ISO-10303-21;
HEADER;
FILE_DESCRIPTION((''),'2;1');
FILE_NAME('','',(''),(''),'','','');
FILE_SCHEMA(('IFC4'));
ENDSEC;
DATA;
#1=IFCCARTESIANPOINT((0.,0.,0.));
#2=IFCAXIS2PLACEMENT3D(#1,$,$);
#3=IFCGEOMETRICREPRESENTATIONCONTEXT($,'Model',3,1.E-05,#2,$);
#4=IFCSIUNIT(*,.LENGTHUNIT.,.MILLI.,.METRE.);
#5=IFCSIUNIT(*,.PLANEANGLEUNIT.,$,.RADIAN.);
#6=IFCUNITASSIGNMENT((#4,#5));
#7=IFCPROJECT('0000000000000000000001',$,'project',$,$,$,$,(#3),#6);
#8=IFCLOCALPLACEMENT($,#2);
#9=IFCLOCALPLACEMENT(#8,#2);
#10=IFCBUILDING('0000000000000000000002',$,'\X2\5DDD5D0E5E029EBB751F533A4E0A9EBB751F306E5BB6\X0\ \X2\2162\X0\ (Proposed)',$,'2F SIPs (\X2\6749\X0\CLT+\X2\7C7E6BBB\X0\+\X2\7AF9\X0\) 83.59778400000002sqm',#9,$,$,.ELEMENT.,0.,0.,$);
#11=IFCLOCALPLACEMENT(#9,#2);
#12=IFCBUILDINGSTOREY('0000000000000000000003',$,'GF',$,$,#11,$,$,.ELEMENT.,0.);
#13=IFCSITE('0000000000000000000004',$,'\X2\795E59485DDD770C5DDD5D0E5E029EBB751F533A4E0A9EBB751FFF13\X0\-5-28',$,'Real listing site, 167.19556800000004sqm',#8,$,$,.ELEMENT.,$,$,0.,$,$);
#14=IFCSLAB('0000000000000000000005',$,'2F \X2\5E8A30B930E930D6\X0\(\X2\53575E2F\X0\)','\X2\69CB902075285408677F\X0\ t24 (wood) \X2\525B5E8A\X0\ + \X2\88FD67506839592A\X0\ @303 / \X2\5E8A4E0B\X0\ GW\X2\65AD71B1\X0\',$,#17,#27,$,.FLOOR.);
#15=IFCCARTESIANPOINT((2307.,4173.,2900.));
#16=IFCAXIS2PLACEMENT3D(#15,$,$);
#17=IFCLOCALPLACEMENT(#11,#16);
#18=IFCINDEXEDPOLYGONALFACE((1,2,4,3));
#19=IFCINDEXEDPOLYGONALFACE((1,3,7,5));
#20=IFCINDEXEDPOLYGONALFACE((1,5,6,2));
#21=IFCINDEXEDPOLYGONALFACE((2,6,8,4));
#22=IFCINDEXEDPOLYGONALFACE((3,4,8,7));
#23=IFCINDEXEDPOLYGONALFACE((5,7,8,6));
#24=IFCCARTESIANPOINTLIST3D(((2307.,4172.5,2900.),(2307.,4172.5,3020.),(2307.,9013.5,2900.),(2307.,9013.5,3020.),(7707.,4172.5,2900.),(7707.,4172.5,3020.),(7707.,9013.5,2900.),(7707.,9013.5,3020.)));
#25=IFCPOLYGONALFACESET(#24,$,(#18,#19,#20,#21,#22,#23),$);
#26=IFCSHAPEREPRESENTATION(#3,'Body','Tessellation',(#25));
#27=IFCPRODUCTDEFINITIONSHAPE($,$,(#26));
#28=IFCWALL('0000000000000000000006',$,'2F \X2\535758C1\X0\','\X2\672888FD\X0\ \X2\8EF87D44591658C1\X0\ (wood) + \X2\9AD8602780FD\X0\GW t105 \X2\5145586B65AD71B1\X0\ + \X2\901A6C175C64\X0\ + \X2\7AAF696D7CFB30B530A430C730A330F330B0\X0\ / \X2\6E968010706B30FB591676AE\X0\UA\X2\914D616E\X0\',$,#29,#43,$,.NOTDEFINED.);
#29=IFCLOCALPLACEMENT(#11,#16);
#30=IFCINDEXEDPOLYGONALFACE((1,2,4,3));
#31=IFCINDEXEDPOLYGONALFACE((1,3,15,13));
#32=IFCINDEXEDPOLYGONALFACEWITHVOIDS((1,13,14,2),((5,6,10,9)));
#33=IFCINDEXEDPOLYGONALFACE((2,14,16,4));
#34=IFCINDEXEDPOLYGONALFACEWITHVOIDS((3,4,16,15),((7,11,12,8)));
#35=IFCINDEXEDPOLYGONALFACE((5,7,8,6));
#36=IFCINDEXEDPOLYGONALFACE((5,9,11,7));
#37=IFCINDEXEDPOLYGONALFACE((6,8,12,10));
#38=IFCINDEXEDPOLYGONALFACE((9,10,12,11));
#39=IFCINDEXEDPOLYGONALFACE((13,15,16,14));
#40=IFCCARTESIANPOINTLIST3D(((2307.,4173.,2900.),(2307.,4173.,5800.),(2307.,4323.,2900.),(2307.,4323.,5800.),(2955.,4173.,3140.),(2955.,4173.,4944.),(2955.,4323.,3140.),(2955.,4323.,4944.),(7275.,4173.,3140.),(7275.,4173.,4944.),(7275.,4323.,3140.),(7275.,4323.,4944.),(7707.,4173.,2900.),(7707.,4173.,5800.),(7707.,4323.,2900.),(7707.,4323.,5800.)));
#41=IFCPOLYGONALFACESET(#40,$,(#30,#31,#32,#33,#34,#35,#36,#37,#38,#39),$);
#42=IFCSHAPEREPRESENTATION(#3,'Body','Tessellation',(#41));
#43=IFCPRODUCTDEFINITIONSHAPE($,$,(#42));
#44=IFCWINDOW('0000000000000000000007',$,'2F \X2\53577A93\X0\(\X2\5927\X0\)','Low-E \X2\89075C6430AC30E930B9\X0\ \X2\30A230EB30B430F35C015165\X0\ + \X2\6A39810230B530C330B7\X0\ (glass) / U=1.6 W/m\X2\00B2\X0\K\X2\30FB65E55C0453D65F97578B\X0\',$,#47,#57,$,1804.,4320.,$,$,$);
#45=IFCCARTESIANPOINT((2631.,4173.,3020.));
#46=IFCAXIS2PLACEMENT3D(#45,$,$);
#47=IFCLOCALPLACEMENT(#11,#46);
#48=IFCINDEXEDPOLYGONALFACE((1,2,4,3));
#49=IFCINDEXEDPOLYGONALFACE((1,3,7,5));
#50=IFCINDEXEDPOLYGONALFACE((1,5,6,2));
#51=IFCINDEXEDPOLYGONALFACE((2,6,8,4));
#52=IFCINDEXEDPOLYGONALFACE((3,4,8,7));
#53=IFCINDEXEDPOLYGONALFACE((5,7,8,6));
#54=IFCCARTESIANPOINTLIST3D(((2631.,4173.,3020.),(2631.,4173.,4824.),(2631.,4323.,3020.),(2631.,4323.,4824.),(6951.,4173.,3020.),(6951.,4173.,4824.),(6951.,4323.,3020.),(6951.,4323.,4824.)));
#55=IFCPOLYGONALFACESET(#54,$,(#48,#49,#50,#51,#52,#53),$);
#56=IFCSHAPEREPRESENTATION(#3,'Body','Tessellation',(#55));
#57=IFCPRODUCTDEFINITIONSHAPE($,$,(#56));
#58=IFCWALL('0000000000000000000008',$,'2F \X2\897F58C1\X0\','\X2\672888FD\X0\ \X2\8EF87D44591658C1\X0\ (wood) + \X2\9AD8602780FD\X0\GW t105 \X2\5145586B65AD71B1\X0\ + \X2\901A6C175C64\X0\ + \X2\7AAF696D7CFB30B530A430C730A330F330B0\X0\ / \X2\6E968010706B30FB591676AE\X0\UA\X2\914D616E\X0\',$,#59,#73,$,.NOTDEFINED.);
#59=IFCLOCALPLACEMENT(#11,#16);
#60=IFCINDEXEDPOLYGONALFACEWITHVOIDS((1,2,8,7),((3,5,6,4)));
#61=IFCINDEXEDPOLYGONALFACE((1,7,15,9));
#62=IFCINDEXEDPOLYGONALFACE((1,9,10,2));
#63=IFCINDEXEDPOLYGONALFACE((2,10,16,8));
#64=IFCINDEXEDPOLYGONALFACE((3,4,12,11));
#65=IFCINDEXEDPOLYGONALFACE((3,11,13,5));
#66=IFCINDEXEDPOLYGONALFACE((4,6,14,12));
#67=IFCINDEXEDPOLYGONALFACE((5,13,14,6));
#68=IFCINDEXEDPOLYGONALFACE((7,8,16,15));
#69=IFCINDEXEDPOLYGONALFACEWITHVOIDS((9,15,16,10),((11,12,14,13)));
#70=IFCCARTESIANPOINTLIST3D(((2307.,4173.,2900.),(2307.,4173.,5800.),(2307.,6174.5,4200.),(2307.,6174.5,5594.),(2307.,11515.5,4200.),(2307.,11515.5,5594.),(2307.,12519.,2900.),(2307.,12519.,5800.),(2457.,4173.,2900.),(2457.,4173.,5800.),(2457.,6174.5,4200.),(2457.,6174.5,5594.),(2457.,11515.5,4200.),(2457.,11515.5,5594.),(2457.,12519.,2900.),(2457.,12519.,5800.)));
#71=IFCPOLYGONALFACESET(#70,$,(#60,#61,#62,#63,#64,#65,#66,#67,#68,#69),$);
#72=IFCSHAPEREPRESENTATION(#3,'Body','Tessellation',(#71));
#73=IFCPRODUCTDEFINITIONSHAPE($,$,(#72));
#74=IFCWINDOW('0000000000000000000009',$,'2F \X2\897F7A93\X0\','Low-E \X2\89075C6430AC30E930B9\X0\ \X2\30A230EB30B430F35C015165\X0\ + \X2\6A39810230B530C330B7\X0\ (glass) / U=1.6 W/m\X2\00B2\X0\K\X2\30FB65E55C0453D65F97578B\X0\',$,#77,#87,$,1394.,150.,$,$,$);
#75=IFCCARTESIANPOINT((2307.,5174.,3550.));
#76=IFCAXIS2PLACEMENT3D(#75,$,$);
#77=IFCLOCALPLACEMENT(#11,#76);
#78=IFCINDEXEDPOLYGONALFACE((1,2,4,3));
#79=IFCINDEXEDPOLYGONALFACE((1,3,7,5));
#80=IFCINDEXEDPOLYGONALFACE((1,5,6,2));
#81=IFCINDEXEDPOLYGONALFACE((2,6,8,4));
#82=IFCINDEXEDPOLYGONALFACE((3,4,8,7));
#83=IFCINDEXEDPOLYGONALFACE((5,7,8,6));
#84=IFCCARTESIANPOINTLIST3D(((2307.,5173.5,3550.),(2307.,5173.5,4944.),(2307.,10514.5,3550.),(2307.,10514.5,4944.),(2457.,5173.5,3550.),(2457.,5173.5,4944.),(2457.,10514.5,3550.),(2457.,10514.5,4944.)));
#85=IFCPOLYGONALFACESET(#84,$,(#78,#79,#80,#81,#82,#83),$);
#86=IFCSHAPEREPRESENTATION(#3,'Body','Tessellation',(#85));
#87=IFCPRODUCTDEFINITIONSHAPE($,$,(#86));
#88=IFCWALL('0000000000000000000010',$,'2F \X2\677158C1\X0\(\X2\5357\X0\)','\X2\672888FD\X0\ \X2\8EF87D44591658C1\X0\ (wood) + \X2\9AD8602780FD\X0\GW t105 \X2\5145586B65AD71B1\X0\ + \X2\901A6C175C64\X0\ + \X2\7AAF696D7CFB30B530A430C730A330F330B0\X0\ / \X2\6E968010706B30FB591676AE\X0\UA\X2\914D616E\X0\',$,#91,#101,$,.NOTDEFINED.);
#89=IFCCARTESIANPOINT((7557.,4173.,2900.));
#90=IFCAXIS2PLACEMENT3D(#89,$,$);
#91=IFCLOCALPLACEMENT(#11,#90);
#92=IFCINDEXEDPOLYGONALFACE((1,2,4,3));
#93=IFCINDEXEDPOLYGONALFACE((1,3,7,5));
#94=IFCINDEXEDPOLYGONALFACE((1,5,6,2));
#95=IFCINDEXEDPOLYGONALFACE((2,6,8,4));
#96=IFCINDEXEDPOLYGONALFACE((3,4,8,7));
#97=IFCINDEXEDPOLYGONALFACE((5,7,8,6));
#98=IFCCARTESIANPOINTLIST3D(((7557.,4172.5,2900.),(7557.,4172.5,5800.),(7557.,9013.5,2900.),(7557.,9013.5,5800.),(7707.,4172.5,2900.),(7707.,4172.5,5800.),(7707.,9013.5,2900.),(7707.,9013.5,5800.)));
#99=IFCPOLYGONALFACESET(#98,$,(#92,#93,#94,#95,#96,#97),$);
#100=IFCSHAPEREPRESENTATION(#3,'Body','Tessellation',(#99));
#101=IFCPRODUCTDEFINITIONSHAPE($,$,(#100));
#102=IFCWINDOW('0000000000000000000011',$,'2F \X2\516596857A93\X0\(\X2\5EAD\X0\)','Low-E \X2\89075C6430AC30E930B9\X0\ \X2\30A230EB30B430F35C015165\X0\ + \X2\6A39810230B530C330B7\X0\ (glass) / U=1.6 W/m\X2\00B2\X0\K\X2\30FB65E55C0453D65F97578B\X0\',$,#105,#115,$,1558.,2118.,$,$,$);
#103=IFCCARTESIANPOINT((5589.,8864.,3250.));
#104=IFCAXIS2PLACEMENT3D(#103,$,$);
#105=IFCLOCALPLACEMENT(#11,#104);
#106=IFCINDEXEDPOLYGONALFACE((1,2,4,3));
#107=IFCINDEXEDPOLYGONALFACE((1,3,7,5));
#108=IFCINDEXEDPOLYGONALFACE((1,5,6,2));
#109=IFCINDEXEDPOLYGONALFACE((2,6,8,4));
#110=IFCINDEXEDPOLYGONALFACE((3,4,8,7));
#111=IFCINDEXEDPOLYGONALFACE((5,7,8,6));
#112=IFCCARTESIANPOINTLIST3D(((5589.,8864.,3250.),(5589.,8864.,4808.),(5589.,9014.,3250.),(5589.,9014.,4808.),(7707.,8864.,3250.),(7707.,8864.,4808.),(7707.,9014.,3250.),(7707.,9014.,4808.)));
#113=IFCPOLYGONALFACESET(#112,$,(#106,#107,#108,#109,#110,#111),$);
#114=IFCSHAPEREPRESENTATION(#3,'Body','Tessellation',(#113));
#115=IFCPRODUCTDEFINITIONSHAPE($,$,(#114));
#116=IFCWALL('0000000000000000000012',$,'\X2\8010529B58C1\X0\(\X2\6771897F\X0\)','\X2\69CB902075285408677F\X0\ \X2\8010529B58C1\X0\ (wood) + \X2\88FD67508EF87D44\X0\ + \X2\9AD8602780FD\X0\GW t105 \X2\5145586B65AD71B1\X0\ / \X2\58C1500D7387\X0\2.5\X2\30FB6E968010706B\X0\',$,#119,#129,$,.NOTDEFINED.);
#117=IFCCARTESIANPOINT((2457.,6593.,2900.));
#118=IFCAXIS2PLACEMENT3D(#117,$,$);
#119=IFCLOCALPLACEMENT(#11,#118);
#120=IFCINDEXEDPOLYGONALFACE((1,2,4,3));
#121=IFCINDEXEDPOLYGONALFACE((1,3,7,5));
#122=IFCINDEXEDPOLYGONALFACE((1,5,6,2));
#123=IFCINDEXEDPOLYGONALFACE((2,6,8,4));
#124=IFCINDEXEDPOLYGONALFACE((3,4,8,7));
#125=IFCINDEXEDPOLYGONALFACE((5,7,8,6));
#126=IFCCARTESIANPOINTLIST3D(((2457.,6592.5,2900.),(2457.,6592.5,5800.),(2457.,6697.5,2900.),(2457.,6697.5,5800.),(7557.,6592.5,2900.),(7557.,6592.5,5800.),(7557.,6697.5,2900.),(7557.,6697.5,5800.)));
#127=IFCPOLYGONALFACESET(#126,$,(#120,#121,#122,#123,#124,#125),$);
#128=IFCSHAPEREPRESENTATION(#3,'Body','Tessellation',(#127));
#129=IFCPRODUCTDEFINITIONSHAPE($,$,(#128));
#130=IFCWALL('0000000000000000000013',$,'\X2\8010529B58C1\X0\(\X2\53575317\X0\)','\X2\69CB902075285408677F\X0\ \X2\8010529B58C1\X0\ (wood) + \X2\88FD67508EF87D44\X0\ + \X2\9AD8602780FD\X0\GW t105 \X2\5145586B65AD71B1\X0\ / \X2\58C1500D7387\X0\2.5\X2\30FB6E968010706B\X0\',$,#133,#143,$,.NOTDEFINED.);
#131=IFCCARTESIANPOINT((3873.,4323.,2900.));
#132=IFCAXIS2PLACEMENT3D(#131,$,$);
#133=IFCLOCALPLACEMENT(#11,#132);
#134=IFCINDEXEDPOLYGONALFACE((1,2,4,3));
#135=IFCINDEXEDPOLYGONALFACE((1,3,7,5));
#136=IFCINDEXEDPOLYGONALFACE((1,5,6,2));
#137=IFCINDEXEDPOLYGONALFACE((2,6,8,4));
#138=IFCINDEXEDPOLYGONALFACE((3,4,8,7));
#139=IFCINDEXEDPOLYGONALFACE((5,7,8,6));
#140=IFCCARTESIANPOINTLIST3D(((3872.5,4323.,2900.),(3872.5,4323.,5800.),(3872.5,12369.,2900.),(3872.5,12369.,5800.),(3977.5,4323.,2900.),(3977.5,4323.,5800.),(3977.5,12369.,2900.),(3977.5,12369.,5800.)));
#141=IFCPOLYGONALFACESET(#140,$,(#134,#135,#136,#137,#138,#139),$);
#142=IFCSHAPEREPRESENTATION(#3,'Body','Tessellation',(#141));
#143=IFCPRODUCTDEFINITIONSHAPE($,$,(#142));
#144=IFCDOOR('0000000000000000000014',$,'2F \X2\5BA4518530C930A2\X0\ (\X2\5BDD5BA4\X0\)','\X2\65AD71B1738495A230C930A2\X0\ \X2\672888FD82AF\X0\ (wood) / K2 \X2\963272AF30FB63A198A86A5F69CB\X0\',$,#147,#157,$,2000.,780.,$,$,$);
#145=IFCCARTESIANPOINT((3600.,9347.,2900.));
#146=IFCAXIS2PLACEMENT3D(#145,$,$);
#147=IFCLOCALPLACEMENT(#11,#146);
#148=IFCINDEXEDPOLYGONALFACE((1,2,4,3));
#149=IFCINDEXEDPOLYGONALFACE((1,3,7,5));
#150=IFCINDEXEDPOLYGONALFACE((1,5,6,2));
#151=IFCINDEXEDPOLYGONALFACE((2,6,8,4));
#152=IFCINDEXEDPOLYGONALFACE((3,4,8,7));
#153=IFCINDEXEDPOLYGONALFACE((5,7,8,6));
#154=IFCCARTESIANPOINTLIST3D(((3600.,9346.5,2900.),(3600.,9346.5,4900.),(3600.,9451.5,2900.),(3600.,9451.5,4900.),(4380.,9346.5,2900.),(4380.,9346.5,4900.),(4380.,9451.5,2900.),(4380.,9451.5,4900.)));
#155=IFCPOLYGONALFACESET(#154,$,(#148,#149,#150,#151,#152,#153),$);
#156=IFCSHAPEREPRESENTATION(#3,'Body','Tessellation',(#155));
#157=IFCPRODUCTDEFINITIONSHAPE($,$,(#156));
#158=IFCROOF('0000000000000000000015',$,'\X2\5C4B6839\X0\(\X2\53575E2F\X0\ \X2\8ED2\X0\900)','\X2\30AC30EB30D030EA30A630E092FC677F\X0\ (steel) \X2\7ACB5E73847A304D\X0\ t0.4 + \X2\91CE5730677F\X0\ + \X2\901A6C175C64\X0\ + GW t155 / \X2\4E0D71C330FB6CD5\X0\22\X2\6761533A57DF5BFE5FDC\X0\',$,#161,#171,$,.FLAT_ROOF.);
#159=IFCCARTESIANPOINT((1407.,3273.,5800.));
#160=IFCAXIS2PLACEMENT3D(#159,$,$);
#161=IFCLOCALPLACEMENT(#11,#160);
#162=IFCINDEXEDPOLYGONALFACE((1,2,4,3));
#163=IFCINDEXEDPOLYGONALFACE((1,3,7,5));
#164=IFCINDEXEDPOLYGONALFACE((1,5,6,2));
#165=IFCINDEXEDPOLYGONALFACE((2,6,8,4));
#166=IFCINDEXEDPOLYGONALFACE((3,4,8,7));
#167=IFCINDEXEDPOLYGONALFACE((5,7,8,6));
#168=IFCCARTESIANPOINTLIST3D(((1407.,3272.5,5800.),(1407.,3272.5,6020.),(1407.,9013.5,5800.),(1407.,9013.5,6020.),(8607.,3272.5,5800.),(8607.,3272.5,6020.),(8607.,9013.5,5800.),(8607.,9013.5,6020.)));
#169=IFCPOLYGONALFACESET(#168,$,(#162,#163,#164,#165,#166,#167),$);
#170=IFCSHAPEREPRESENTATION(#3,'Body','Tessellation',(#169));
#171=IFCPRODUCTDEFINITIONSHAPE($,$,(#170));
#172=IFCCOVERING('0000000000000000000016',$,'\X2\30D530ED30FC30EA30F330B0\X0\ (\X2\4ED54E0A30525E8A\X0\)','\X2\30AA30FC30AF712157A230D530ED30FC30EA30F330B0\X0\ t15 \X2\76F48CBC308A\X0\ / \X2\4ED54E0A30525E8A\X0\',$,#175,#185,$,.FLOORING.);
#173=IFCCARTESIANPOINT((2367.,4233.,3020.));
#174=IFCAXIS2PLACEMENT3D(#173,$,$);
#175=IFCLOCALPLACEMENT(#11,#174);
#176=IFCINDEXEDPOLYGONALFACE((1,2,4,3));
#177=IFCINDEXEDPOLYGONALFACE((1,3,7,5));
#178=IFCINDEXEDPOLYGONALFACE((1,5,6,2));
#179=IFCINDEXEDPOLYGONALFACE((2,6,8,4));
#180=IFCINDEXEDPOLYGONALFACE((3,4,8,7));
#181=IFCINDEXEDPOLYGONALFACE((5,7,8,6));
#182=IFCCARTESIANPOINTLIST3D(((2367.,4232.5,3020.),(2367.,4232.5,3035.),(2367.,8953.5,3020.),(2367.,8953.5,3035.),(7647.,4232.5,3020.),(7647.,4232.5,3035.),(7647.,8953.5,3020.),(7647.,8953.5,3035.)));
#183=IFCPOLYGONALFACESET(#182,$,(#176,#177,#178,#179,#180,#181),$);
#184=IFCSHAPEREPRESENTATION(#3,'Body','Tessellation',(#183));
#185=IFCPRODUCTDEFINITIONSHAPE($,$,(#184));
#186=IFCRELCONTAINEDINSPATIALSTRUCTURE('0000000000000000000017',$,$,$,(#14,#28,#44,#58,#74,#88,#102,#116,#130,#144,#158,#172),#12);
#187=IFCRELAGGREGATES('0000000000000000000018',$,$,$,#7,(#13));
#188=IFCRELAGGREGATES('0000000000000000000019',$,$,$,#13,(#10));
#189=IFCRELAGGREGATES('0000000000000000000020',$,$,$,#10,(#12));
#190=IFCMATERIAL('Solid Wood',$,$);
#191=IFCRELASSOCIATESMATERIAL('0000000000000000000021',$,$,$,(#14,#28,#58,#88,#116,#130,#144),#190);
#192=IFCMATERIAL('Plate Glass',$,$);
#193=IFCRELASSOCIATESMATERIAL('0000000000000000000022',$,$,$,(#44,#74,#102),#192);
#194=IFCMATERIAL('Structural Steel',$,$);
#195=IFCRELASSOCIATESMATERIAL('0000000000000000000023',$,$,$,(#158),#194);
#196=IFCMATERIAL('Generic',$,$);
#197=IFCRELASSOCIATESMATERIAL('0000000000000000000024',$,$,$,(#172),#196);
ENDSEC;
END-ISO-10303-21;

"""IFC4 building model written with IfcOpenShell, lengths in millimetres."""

from ifc_helpers import new_model, si_unit, frame, frame_2d, origin, place, context, project, spatial, rectangle, extrude, material, element, fill, save


model = new_model("IFC4")

# Units and contexts
model_context = context("Model", 3, precision=1e-05, world=origin())
ifc_project = project(units=[si_unit("LENGTHUNIT", "METRE", prefix="MILLI"), si_unit("PLANEANGLEUNIT", "RADIAN")], contexts=[model_context])

# Site, building, storey
site_placement = place(None, origin())
site = spatial("IfcSite", under=ifc_project, at=site_placement, Name="神奈川県川崎市麻生区上麻生３-5-28", ObjectType="Real listing site, 167.19556800000004sqm", CompositionType="ELEMENT", RefElevation=0.0)
building_placement = place(site_placement, origin())
building = spatial("IfcBuilding", under=site, at=building_placement, Name="川崎市麻生区上麻生の家 Ⅲ (Proposed)", ObjectType="2F SIPs (杉CLT+籾殻+竹) 83.59778400000002sqm", CompositionType="ELEMENT", ElevationOfRefHeight=0.0, ElevationOfTerrain=0.0)
storey_placement = place(building_placement, origin())
storey = spatial("IfcBuildingStorey", under=building, at=storey_placement, Name="GF", CompositionType="ELEMENT", Elevation=0.0)

# Slab
ifc_material_1 = material(Name="Solid Wood")
slab_placement = place(storey_placement, frame((2307.0, 4173.0, 2900.0)))
element("IfcSlab", 1, at=slab_placement, inside=storey, material=ifc_material_1, Name="2F 床スラブ(南帯)", Description="構造用合板 t24 (wood) 剛床 + 製材根太 @303 / 床下 GW断熱", PredefinedType="FLOOR", context=model_context, shape_type="SweptSolid", body=[
    extrude(rectangle(XDim=5400.0, YDim=4841.0, at=frame_2d((2700.0, 2420.0))), frame((2307.0, 4173.0, 2900.0)), (0.0, 0.0, 1.0), 120.0),
])

# Walls, openings, windows
wall_1_placement = place(storey_placement, frame((2307.0, 4173.0, 2900.0)))
wall_1 = element("IfcWall", 2, at=wall_1_placement, inside=storey, material=ifc_material_1, Name="2F 南壁", Description="木製 軸組外壁 (wood) + 高性能GW t105 充填断熱 + 通気層 + 窯業系サイディング / 準耐火・外皮UA配慮", PredefinedType="NOTDEFINED", context=model_context, shape_type="SweptSolid", body=[
    extrude(rectangle(XDim=5400.0, YDim=150.0, at=frame_2d((2700.0, 75.0))), frame((2307.0, 4173.0, 2900.0)), (0.0, 0.0, 1.0), 2900.0),
])
opening_1_placement = place(storey_placement, frame((2631.0, 4173.0, 3020.0)))
opening_1 = element("IfcOpeningElement", 3, at=opening_1_placement, cuts=wall_1, PredefinedType="NOTDEFINED", context=model_context, shape_type="SweptSolid", body=[
    extrude(rectangle(XDim=4320.0, YDim=150.0, at=frame_2d((2160.0, 75.0))), frame((2631.0, 4173.0, 3020.0)), (0.0, 0.0, 1.0), 1804.0),
])
ifc_material_2 = material(Name="Plate Glass")
window_1_placement = place(storey_placement, frame((2631.0, 4173.0, 3020.0)))
window_1 = element("IfcWindow", 4, at=window_1_placement, inside=storey, material=ifc_material_2, Name="2F 南窓(大)", Description="Low-E 複層ガラス アルゴン封入 + 樹脂サッシ (glass) / U=1.6 W/m²K・日射取得型", OverallHeight=1804.0, OverallWidth=4320.0, context=model_context, shape_type="SweptSolid", body=[
    extrude(rectangle(XDim=4320.0, YDim=150.0, at=frame_2d((2160.0, 75.0))), frame((2631.0, 4173.0, 3020.0)), (0.0, 0.0, 1.0), 1804.0),
])
fill(opening_1, window_1)
wall_2_placement = place(storey_placement, frame((2307.0, 4173.0, 2900.0)))
wall_2 = element("IfcWall", 5, at=wall_2_placement, inside=storey, material=ifc_material_1, Name="2F 西壁", Description="木製 軸組外壁 (wood) + 高性能GW t105 充填断熱 + 通気層 + 窯業系サイディング / 準耐火・外皮UA配慮", PredefinedType="NOTDEFINED", context=model_context, shape_type="SweptSolid", body=[
    extrude(rectangle(XDim=150.0, YDim=8346.0, at=frame_2d((75.0, 4173.0))), frame((2307.0, 4173.0, 2900.0)), (0.0, 0.0, 1.0), 2900.0),
])
opening_2_placement = place(storey_placement, frame((2307.0, 5174.0, 3550.0)))
opening_2 = element("IfcOpeningElement", 6, at=opening_2_placement, cuts=wall_2, PredefinedType="NOTDEFINED", context=model_context, shape_type="SweptSolid", body=[
    extrude(rectangle(XDim=150.0, YDim=5341.0, at=frame_2d((75.0, 2670.0))), frame((2307.0, 5174.0, 3550.0)), (0.0, 0.0, 1.0), 1394.0),
])
window_2_placement = place(storey_placement, frame((2307.0, 5174.0, 3550.0)))
window_2 = element("IfcWindow", 7, at=window_2_placement, inside=storey, material=ifc_material_2, Name="2F 西窓", Description="Low-E 複層ガラス アルゴン封入 + 樹脂サッシ (glass) / U=1.6 W/m²K・日射取得型", OverallHeight=1394.0, OverallWidth=150.0, context=model_context, shape_type="SweptSolid", body=[
    extrude(rectangle(XDim=150.0, YDim=5341.0, at=frame_2d((75.0, 2670.0))), frame((2307.0, 5174.0, 3550.0)), (0.0, 0.0, 1.0), 1394.0),
])
fill(opening_2, window_2)
wall_3_placement = place(storey_placement, frame((7557.0, 4173.0, 2900.0)))
wall_3 = element("IfcWall", 8, at=wall_3_placement, inside=storey, material=ifc_material_1, Name="2F 東壁(南)", Description="木製 軸組外壁 (wood) + 高性能GW t105 充填断熱 + 通気層 + 窯業系サイディング / 準耐火・外皮UA配慮", PredefinedType="NOTDEFINED", context=model_context, shape_type="SweptSolid", body=[
    extrude(rectangle(XDim=150.0, YDim=4841.0, at=frame_2d((75.0, 2420.0))), frame((7557.0, 4173.0, 2900.0)), (0.0, 0.0, 1.0), 2900.0),
])
opening_3_placement = place(storey_placement, frame((5589.0, 8864.0, 3250.0)))
opening_3 = element("IfcOpeningElement", 9, at=opening_3_placement, cuts=wall_3, PredefinedType="NOTDEFINED", context=model_context, shape_type="SweptSolid", body=[
    extrude(rectangle(XDim=2118.0, YDim=150.0, at=frame_2d((1059.0, 75.0))), frame((5589.0, 8864.0, 3250.0)), (0.0, 0.0, 1.0), 1558.0),
])
window_3_placement = place(storey_placement, frame((5589.0, 8864.0, 3250.0)))
window_3 = element("IfcWindow", 10, at=window_3_placement, inside=storey, material=ifc_material_2, Name="2F 入隅窓(庭)", Description="Low-E 複層ガラス アルゴン封入 + 樹脂サッシ (glass) / U=1.6 W/m²K・日射取得型", OverallHeight=1558.0, OverallWidth=2118.0, context=model_context, shape_type="SweptSolid", body=[
    extrude(rectangle(XDim=2118.0, YDim=150.0, at=frame_2d((1059.0, 75.0))), frame((5589.0, 8864.0, 3250.0)), (0.0, 0.0, 1.0), 1558.0),
])
fill(opening_3, window_3)

# Wall
wall_4_placement = place(storey_placement, frame((2457.0, 6593.0, 2900.0)))
element("IfcWall", 11, at=wall_4_placement, inside=storey, material=ifc_material_1, Name="耐力壁(東西)", Description="構造用合板 耐力壁 (wood) + 製材軸組 + 高性能GW t105 充填断熱 / 壁倍率2.5・準耐火", PredefinedType="NOTDEFINED", context=model_context, shape_type="SweptSolid", body=[
    extrude(rectangle(XDim=5100.0, YDim=105.0, at=frame_2d((2550.0, 52.0))), frame((2457.0, 6593.0, 2900.0)), (0.0, 0.0, 1.0), 2900.0),
])

# Wall, opening, door
wall_5_placement = place(storey_placement, frame((3873.0, 4323.0, 2900.0)))
wall_5 = element("IfcWall", 12, at=wall_5_placement, inside=storey, material=ifc_material_1, Name="耐力壁(南北)", Description="構造用合板 耐力壁 (wood) + 製材軸組 + 高性能GW t105 充填断熱 / 壁倍率2.5・準耐火", PredefinedType="NOTDEFINED", context=model_context, shape_type="SweptSolid", body=[
    extrude(rectangle(XDim=105.0, YDim=8046.0, at=frame_2d((52.0, 4023.0))), frame((3873.0, 4323.0, 2900.0)), (0.0, 0.0, 1.0), 2900.0),
])
opening_4_placement = place(storey_placement, frame((3600.0, 9347.0, 2900.0)))
opening_4 = element("IfcOpeningElement", 13, at=opening_4_placement, cuts=wall_5, PredefinedType="NOTDEFINED", context=model_context, shape_type="SweptSolid", body=[
    extrude(rectangle(XDim=780.0, YDim=105.0, at=frame_2d((390.0, 52.0))), frame((3600.0, 9347.0, 2900.0)), (0.0, 0.0, 1.0), 2000.0),
])
door_placement = place(storey_placement, frame((3600.0, 9347.0, 2900.0)))
door = element("IfcDoor", 14, at=door_placement, inside=storey, material=ifc_material_1, Name="2F 室内ドア (寝室)", Description="断熱玄関ドア 木製芯 (wood) / K2 防犯・採風機構", OverallHeight=2000.0, OverallWidth=780.0, context=model_context, shape_type="SweptSolid", body=[
    extrude(rectangle(XDim=780.0, YDim=105.0, at=frame_2d((390.0, 52.0))), frame((3600.0, 9347.0, 2900.0)), (0.0, 0.0, 1.0), 2000.0),
])
fill(opening_4, door)

# Roof
ifc_material_3 = material(Name="Structural Steel")
for number, where, name in (
    (15, (1407.0, 3273.0, 5800.0), "屋根(南帯 軒900)"),
):
    element("IfcRoof", number, at=place(storey_placement, frame(where)), inside=storey, material=ifc_material_3, Name=name, Description="ガルバリウム鋼板 (steel) 立平葺き t0.4 + 野地板 + 通気層 + GW t155 / 不燃・法22条区域対応", PredefinedType="FLAT_ROOF", context=model_context, shape_type="SweptSolid", body=[
        extrude(rectangle(XDim=7200.0, YDim=5741.0, at=frame_2d((3600.0, 2870.0))), frame((1407.0, 3273.0, 5800.0)), (0.0, 0.0, 1.0), 220.0),
    ])

# Covering
ifc_material_4 = material(Name="Generic")
covering_placement = place(storey_placement, frame((2367.0, 4233.0, 3020.0)))
element("IfcCovering", 16, at=covering_placement, inside=storey, material=ifc_material_4, Name="フローリング (仕上げ床)", Description="オーク無垢フローリング t15 直貼り / 仕上げ床", PredefinedType="FLOORING", context=model_context, shape_type="SweptSolid", body=[
    extrude(rectangle(XDim=5280.0, YDim=4721.0, at=frame_2d((2640.0, 2360.0))), frame((2367.0, 4233.0, 3020.0)), (0.0, 0.0, 1.0), 15.0),
])

save(model, "model.ifc")
